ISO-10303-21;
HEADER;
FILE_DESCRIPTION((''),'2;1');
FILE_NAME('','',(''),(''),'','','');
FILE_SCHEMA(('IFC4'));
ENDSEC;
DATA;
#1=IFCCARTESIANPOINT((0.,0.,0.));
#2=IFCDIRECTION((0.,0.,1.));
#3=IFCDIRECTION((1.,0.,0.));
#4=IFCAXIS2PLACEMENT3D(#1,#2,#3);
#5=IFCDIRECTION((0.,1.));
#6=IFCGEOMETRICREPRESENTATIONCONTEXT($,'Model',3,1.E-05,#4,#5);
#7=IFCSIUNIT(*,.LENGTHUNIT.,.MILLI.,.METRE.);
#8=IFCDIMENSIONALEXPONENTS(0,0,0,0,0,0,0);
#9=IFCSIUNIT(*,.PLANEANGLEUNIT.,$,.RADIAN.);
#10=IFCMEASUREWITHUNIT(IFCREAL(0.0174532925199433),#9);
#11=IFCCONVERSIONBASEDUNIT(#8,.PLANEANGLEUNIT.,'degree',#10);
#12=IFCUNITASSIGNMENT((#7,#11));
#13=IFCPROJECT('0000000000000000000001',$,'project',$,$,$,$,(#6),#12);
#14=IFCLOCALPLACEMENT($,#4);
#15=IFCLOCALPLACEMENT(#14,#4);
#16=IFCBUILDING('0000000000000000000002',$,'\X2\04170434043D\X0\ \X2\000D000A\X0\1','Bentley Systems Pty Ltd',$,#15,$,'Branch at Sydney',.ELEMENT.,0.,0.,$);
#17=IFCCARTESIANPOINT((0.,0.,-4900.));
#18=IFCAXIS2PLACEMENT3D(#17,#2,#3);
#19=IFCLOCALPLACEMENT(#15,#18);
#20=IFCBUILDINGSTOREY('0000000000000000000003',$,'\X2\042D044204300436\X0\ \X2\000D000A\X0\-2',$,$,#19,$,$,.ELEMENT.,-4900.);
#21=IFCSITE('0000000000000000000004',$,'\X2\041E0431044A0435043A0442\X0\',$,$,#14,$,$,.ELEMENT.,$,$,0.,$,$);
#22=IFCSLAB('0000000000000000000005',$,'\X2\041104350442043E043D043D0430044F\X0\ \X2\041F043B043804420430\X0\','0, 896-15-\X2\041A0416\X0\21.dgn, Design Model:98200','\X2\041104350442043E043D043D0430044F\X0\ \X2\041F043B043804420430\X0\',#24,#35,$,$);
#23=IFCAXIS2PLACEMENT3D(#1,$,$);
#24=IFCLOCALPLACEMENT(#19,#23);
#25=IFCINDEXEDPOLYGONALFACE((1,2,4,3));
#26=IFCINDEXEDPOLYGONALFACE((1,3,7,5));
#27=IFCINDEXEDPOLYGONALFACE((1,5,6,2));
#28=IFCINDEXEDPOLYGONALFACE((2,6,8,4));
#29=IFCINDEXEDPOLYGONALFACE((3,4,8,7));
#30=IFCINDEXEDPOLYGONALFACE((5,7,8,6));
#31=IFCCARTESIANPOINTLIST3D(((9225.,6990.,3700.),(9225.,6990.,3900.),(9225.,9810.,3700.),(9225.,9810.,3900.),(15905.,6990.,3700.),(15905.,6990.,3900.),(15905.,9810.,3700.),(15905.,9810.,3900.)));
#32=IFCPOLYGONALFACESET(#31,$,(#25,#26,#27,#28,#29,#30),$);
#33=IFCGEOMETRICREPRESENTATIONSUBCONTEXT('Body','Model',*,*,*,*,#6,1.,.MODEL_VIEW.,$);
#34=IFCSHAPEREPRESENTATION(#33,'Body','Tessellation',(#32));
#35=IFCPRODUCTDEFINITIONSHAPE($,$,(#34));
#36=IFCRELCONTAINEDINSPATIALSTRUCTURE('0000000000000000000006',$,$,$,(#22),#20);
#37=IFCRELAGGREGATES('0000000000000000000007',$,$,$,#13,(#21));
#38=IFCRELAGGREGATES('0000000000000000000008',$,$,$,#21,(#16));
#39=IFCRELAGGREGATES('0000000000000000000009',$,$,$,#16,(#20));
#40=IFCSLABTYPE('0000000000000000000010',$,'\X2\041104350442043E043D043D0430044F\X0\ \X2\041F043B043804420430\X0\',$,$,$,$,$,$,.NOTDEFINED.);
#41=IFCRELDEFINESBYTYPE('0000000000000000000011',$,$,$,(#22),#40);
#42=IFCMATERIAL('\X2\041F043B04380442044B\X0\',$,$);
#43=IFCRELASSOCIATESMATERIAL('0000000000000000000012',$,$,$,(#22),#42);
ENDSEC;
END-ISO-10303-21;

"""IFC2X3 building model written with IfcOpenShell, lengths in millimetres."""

from ifc_helpers import new_model, entity, si_unit, converted_unit, direction, frame, frame_2d, origin_with_axes, place, context, subcontext, project, spatial, rectangle, extrude, material, type_object, element, save


model = new_model("IFC2X3")

# Units and contexts
model_context = context("Model", 3, precision=1e-05, world=origin_with_axes(), true_north=direction((0.0, 1.0)))
body_context = subcontext(model_context, "Body", "Model", "MODEL_VIEW", scale=1.0)
ifc_project = project(units=[si_unit("LENGTHUNIT", "METRE", prefix="MILLI"), converted_unit("PLANEANGLEUNIT", "degree", entity("IfcReal", 0.0174532925199433), si_unit("PLANEANGLEUNIT", "RADIAN"), dimensions=[0, 0, 0, 0, 0, 0, 0])], contexts=[model_context])

# Site, building, storey
site_placement = place(None, origin_with_axes())
site = spatial("IfcSite", under=ifc_project, at=site_placement, Name="Объект", CompositionType="ELEMENT", RefElevation=0.0)
building_placement = place(site_placement, origin_with_axes())
building = spatial("IfcBuilding", under=site, at=building_placement, Name="Здн \r\n1", Description="Bentley Systems Pty Ltd", LongName="Branch at Sydney", CompositionType="ELEMENT", ElevationOfRefHeight=0.0, ElevationOfTerrain=0.0)
storey_placement = place(building_placement, frame((0.0, 0.0, -4900.0), z_axis=(0.0, 0.0, 1.0), x_axis=(1.0, 0.0, 0.0)))
storey = spatial("IfcBuildingStorey", under=building, at=storey_placement, Name="Этаж \r\n-2", CompositionType="ELEMENT", Elevation=-4900.0)

# Slab
ifc_material_1 = material(Name="Плиты")
slab_type = type_object("IfcSlabType", Name="Бетонная Плита", PredefinedType="NOTDEFINED")
slab_1_placement = place(storey_placement, frame((15905.0, 9810.0, 3900.0), z_axis=(0.0, 0.0, -1.0), x_axis=(0.0, -1.0, 0.0)))
element("IfcSlab", 1, at=slab_1_placement, inside=storey, type_object=slab_type, material=ifc_material_1, Name="Бетонная Плита", Description="0, 896-15-КЖ21.dgn, Design Model:98200", ObjectType="Бетонная Плита", context=body_context, shape_type="SweptSolid", body=[
    extrude(rectangle(XDim=2820.0, YDim=6680.0, at=frame_2d((1410.0, 3340.0), x_axis=(1.0, 0.0))), origin_with_axes(), (0.0, 0.0, 1.0), 200.0),
])

save(model, "model.ifc")
